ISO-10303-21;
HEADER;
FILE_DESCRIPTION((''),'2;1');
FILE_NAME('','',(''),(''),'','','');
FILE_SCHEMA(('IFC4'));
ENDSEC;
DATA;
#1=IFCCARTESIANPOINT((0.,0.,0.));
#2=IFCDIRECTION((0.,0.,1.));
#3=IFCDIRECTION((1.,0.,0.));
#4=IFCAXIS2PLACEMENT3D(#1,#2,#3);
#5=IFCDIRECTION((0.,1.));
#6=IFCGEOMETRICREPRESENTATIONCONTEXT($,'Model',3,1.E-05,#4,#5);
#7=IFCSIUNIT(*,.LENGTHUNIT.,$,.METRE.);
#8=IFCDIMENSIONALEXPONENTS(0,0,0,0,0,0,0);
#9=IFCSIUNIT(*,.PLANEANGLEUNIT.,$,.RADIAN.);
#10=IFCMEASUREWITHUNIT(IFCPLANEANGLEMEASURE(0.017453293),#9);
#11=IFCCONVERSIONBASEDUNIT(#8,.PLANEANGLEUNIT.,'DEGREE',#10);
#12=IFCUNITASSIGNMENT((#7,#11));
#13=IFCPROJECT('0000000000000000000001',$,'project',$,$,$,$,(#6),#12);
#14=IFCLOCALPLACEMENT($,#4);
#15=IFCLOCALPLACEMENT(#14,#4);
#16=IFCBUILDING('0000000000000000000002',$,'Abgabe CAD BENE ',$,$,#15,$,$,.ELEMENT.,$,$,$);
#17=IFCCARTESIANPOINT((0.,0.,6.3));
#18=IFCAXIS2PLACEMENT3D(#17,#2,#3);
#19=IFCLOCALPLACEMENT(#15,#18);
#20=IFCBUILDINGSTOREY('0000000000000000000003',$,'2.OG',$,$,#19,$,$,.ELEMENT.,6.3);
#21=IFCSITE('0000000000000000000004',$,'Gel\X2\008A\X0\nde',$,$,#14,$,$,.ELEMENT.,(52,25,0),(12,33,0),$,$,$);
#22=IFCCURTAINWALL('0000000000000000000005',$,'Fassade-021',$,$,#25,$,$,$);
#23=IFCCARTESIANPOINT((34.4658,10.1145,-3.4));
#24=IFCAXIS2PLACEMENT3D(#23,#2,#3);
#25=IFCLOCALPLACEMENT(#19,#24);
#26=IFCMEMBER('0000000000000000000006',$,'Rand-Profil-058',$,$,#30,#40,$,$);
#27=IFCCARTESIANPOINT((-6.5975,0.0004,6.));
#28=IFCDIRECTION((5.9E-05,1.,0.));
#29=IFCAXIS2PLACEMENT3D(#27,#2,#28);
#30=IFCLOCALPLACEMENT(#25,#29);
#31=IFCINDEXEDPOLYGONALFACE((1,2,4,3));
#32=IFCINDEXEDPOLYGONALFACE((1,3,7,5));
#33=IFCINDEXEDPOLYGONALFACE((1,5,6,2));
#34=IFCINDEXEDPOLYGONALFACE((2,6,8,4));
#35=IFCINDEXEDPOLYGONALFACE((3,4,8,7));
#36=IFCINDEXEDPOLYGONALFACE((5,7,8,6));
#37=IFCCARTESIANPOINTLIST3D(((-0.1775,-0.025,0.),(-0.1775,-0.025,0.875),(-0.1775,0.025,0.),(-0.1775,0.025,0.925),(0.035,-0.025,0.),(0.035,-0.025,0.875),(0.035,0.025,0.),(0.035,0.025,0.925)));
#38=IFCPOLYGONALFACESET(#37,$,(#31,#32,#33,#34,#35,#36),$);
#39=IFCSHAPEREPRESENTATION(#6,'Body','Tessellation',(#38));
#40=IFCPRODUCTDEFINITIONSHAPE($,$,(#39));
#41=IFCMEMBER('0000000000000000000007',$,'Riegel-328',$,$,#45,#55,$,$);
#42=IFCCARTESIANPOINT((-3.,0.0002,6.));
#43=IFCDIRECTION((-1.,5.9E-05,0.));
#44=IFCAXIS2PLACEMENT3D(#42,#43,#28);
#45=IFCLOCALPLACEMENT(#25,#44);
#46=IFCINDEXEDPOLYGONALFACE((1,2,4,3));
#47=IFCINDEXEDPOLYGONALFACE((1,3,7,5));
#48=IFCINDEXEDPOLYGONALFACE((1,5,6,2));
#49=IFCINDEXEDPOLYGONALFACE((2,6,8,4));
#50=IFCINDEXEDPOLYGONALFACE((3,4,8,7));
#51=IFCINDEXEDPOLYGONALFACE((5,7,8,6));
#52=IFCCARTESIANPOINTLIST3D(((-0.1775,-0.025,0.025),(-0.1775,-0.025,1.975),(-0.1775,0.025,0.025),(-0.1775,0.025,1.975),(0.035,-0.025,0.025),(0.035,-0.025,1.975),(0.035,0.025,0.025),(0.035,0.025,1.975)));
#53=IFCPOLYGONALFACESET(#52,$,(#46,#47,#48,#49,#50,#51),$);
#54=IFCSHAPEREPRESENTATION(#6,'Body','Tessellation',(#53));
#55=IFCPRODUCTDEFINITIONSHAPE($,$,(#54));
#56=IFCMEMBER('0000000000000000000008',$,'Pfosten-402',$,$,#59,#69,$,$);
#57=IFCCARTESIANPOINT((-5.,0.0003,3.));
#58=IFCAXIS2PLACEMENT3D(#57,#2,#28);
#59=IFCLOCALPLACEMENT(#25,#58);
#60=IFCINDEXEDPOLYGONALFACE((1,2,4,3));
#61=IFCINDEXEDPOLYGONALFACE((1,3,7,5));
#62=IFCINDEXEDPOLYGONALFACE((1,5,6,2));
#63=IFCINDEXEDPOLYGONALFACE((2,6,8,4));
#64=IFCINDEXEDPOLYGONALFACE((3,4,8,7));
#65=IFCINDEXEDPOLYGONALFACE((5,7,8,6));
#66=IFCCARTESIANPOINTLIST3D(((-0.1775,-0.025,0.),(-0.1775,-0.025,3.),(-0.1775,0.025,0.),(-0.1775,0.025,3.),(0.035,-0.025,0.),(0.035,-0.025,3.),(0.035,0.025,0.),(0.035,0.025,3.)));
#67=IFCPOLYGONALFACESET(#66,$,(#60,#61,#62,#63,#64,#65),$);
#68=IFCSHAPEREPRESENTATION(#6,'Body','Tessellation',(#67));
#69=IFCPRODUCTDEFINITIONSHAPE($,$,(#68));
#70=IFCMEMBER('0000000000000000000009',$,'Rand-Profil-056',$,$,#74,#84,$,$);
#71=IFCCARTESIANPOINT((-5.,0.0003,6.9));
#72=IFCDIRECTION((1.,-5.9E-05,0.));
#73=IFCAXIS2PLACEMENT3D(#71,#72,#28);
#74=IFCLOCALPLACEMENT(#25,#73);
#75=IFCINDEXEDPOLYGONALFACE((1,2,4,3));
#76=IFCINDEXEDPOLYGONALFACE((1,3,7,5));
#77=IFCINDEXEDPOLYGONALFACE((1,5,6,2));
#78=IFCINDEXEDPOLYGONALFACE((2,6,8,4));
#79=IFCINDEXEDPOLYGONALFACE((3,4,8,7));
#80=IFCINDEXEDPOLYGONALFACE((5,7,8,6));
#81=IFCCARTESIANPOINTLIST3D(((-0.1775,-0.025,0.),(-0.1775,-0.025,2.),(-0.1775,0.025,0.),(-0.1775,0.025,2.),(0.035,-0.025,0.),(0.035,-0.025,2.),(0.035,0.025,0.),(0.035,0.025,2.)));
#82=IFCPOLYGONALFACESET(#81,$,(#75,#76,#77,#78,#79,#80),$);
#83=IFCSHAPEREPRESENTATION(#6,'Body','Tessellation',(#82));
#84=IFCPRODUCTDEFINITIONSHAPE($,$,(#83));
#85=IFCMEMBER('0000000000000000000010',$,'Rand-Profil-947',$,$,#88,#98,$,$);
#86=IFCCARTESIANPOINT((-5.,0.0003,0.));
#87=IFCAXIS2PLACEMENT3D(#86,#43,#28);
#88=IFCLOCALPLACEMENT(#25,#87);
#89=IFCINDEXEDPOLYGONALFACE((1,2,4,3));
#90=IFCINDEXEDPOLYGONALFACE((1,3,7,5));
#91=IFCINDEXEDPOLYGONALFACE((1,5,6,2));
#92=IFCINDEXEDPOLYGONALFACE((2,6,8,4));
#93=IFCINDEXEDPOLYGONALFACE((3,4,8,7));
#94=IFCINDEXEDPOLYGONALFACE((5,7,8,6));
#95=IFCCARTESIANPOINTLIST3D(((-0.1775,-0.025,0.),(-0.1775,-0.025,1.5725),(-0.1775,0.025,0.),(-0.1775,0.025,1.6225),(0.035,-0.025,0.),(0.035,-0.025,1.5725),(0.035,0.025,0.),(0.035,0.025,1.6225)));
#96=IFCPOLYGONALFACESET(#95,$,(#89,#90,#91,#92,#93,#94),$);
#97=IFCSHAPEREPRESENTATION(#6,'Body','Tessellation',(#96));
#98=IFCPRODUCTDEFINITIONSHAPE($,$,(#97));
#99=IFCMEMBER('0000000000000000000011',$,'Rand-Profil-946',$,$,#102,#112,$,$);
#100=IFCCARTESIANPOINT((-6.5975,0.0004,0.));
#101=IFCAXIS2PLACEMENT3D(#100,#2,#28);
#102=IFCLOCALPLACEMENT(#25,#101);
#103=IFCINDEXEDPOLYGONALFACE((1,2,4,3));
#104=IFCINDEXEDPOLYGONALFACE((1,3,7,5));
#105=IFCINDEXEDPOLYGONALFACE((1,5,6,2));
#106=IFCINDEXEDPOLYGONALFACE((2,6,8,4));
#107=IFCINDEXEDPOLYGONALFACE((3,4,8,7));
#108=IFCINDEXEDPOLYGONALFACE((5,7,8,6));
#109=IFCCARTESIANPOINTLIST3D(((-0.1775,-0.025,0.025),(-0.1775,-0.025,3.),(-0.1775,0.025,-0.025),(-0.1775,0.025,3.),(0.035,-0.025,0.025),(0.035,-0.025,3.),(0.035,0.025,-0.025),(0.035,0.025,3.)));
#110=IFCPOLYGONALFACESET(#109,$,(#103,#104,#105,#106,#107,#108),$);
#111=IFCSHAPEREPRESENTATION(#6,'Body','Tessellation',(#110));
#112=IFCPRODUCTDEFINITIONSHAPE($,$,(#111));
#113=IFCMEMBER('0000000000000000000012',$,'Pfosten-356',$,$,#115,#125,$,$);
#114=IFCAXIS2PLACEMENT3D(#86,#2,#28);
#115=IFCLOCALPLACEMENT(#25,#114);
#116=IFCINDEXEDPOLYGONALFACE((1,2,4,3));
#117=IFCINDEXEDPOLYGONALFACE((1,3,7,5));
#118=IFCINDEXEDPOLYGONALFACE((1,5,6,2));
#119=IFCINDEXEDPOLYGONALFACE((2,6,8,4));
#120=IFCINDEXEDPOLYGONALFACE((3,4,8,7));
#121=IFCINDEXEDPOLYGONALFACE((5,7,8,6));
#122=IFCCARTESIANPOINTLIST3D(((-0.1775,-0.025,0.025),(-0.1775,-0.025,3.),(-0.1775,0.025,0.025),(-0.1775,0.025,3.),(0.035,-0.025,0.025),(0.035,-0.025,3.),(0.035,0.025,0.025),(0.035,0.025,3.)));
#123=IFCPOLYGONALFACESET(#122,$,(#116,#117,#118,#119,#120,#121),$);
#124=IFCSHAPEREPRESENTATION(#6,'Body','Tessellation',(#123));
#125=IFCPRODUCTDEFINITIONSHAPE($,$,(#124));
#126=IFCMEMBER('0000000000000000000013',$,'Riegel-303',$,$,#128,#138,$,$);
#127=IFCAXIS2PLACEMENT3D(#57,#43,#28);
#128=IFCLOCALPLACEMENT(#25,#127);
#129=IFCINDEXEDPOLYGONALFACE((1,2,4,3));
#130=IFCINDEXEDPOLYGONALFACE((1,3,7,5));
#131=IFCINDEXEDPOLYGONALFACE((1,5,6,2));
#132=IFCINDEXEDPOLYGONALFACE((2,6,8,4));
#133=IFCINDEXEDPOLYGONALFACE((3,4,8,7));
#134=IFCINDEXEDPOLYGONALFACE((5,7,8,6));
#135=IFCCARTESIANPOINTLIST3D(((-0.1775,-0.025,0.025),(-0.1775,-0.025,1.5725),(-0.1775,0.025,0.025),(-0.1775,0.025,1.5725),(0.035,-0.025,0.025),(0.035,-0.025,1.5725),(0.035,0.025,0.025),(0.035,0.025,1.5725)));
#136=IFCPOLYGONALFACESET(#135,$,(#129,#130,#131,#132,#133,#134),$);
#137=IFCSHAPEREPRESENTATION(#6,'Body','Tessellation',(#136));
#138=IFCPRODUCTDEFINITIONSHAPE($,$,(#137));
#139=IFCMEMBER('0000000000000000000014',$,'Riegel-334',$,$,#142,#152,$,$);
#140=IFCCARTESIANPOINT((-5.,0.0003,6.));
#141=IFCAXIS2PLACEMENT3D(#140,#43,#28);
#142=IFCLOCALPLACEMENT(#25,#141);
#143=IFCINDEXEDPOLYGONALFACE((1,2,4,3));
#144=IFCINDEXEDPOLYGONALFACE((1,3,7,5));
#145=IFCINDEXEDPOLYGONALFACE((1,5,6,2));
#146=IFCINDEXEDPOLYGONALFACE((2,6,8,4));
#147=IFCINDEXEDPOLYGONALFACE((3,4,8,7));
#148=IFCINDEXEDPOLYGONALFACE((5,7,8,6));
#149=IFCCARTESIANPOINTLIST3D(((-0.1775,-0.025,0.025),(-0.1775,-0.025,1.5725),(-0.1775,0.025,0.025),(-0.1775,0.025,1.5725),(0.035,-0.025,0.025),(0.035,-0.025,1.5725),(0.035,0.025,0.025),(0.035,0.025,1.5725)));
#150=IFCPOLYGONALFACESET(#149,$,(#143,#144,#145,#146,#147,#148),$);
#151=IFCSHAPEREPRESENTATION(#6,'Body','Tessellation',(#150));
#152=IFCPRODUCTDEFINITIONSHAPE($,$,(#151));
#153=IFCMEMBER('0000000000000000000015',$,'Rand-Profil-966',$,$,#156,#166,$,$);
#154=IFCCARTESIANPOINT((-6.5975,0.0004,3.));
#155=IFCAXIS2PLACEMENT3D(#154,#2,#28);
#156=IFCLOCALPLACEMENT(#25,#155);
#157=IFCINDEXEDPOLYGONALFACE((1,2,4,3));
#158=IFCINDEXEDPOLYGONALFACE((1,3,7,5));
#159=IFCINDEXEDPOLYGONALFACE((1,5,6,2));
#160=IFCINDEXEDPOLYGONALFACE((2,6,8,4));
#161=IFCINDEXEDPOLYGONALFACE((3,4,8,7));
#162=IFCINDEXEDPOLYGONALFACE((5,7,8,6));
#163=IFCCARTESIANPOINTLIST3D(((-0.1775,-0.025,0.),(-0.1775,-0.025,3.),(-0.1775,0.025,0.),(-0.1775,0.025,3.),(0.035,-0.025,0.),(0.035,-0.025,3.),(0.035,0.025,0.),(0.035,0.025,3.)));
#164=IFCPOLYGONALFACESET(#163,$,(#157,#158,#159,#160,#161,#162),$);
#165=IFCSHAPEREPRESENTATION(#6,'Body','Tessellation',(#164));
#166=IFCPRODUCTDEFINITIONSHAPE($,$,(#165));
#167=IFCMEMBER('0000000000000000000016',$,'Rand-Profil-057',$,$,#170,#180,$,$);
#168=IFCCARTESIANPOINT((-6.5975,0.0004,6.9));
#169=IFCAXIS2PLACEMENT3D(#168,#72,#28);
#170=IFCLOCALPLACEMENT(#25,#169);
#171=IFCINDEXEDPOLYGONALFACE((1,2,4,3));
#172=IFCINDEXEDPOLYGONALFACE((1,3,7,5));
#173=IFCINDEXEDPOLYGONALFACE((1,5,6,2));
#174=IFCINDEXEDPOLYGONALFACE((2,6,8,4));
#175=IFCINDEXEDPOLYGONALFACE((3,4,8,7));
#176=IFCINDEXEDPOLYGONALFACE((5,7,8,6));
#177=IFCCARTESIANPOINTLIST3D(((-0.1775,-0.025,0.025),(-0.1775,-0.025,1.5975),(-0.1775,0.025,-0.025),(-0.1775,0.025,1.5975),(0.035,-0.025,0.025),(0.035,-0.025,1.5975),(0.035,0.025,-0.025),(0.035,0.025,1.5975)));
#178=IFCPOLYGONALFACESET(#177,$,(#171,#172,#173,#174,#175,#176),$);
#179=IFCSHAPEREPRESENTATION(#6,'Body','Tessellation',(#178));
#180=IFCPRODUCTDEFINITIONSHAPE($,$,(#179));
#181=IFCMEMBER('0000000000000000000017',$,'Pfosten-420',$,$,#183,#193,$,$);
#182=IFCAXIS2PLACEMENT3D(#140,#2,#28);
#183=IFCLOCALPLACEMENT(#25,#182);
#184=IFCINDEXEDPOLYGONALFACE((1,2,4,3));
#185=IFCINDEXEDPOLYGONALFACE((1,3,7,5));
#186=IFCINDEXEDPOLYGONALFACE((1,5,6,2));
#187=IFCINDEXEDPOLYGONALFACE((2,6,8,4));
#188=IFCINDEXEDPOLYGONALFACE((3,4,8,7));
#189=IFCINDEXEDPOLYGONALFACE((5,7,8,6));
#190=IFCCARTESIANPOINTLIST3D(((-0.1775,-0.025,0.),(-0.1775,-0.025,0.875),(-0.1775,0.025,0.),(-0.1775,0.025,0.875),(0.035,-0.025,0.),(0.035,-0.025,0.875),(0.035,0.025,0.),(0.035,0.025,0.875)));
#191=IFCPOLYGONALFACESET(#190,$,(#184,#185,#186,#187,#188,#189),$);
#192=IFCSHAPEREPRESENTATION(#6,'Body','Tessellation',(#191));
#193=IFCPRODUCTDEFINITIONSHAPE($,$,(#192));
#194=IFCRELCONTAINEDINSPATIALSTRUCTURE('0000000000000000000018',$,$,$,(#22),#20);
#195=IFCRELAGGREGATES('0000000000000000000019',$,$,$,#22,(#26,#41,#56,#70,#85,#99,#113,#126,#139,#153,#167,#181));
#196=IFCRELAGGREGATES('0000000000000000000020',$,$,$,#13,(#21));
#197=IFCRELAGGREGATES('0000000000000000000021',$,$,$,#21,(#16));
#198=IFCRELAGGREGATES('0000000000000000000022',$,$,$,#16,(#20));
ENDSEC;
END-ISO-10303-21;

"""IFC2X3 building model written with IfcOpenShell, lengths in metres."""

from ifc_helpers import new_model, entity, si_unit, converted_unit, direction, frame, origin_with_axes, place, context, project, spatial, polyline, outline, extrude, clip, halfspace, element, aggregate, save


model = new_model("IFC2X3")

# Units and contexts
model_context = context("Model", 3, precision=1e-05, world=origin_with_axes(), true_north=direction((0.0, 1.0)))
ifc_project = project(units=[si_unit("LENGTHUNIT", "METRE"), converted_unit("PLANEANGLEUNIT", "DEGREE", entity("IfcPlaneAngleMeasure", 0.017453293), si_unit("PLANEANGLEUNIT", "RADIAN"), dimensions=[0, 0, 0, 0, 0, 0, 0])], contexts=[model_context])

# Site, building, storey
site_placement = place(None, origin_with_axes())
site = spatial("IfcSite", under=ifc_project, at=site_placement, Name="Gel\u008ande", CompositionType="ELEMENT", RefLatitude=(52, 25, 0), RefLongitude=(12, 33, 0))
building_placement = place(site_placement, origin_with_axes())
building = spatial("IfcBuilding", under=site, at=building_placement, Name="Abgabe CAD BENE ", CompositionType="ELEMENT")
storey_placement = place(building_placement, frame((0.0, 0.0, 6.3), z_axis=(0.0, 0.0, 1.0), x_axis=(1.0, 0.0, 0.0)))
storey = spatial("IfcBuildingStorey", under=building, at=storey_placement, Name="2.OG", CompositionType="ELEMENT", Elevation=6.3)

# Curtain wall, members
curtain_wall_placement = place(storey_placement, frame((34.4658, 10.1145, -3.4), z_axis=(0.0, 0.0, 1.0), x_axis=(1.0, 0.0, 0.0)))
curtain_wall = element("IfcCurtainWall", 1, at=curtain_wall_placement, inside=storey, Name="Fassade-021")
member_1_placement = place(curtain_wall_placement, frame((-6.5975, 0.0004, 6.0), z_axis=(0.0, 0.0, 1.0), x_axis=(0.000059, 1.0, 0.0)))
member_1 = element("IfcMember", 2, at=member_1_placement, Name="Rand-Profil-058", context=model_context, shape_type="Clipping", body=[
    clip(extrude(outline(polyline([(0.025, -0.1775), (0.025, 0.035), (-0.025, 0.035), (-0.025, -0.1775), (0.025, -0.1775)])), frame((0.0, 0.0, 0.0), z_axis=(0.0, 0.0, 1.0), x_axis=(0.000059, -1.0, 0.0)), (0.0, 0.0, 1.0), 0.925), halfspace(frame((0.0, -0.45, 0.45), z_axis=(0.0, 0.707107, -0.707107), x_axis=(0.0, -0.707107, -0.707107)), True)),
])
member_2_placement = place(curtain_wall_placement, frame((-3.0, 0.0002, 6.0), z_axis=(-1.0, 0.000059, 0.0), x_axis=(0.000059, 1.0, 0.0)))
member_2 = element("IfcMember", 3, at=member_2_placement, Name="Riegel-328", context=model_context, shape_type="SweptSolid", body=[
    extrude(outline(polyline([(-0.1775, -0.025), (0.035, -0.025), (0.035, 0.025), (-0.1775, 0.025), (-0.1775, -0.025)])), frame((0.0, 0.0, 0.025), z_axis=(0.0, 0.0, 1.0), x_axis=(1.0, 0.0, 0.0)), (0.0, 0.0, 1.0), 1.95),
])
member_3_placement = place(curtain_wall_placement, frame((-5.0, 0.0003, 3.0), z_axis=(0.0, 0.0, 1.0), x_axis=(0.000059, 1.0, 0.0)))
member_3 = element("IfcMember", 4, at=member_3_placement, Name="Pfosten-402", context=model_context, shape_type="SweptSolid", body=[
    extrude(outline(polyline([(0.025, -0.1775), (0.025, 0.035), (-0.025, 0.035), (-0.025, -0.1775), (0.025, -0.1775)])), frame((0.0, 0.0, 0.0), z_axis=(0.0, 0.0, 1.0), x_axis=(0.000059, -1.0, 0.0)), (0.0, 0.0, 1.0), 3.0),
])
member_4_placement = place(curtain_wall_placement, frame((-5.0, 0.0003, 6.9), z_axis=(1.0, -0.000059, 0.0), x_axis=(0.000059, 1.0, 0.0)))
member_4 = element("IfcMember", 5, at=member_4_placement, Name="Rand-Profil-056", context=model_context, shape_type="SweptSolid", body=[
    extrude(outline(polyline([(0.1775, 0.025), (-0.035, 0.025), (-0.035, -0.025), (0.1775, -0.025), (0.1775, 0.025)])), frame((0.0, 0.0, 0.0), z_axis=(0.0, 0.0, 1.0), x_axis=(-1.0, 0.0, 0.0)), (0.0, 0.0, 1.0), 2.0),
])
member_5_placement = place(curtain_wall_placement, frame((-5.0, 0.0003, 0.0), z_axis=(-1.0, 0.000059, 0.0), x_axis=(0.000059, 1.0, 0.0)))
member_5 = element("IfcMember", 6, at=member_5_placement, Name="Rand-Profil-947", context=model_context, shape_type="Clipping", body=[
    clip(extrude(outline(polyline([(-0.1775, -0.025), (0.035, -0.025), (0.035, 0.025), (-0.1775, 0.025), (-0.1775, -0.025)])), origin_with_axes(), (0.0, 0.0, 1.0), 1.6225), halfspace(frame((0.0, -0.7988, 0.7988), z_axis=(0.0, 0.707107, -0.707107), x_axis=(0.0, -0.707107, -0.707107)), True)),
])
member_6_placement = place(curtain_wall_placement, frame((-6.5975, 0.0004, 0.0), z_axis=(0.0, 0.0, 1.0), x_axis=(0.000059, 1.0, 0.0)))
member_6 = element("IfcMember", 7, at=member_6_placement, Name="Rand-Profil-946", context=model_context, shape_type="Clipping", body=[
    clip(extrude(outline(polyline([(0.025, -0.1775), (0.025, 0.035), (-0.025, 0.035), (-0.025, -0.1775), (0.025, -0.1775)])), frame((0.0, 0.0, -0.025), z_axis=(0.0, 0.0, 1.0), x_axis=(0.000059, -1.0, 0.0)), (0.0, 0.0, 1.0), 3.025), halfspace(frame((0.0, 0.0, 0.0), z_axis=(0.0, 0.707107, 0.707107), x_axis=(0.0, 0.707107, -0.707107)), True)),
])
member_7_placement = place(curtain_wall_placement, frame((-5.0, 0.0003, 0.0), z_axis=(0.0, 0.0, 1.0), x_axis=(0.000059, 1.0, 0.0)))
member_7 = element("IfcMember", 8, at=member_7_placement, Name="Pfosten-356", context=model_context, shape_type="SweptSolid", body=[
    extrude(outline(polyline([(0.025, -0.1775), (0.025, 0.035), (-0.025, 0.035), (-0.025, -0.1775), (0.025, -0.1775)])), frame((0.0, 0.0, 0.025), z_axis=(0.0, 0.0, 1.0), x_axis=(0.000059, -1.0, 0.0)), (0.0, 0.0, 1.0), 2.975),
])
member_8_placement = place(curtain_wall_placement, frame((-5.0, 0.0003, 3.0), z_axis=(-1.0, 0.000059, 0.0), x_axis=(0.000059, 1.0, 0.0)))
member_8 = element("IfcMember", 9, at=member_8_placement, Name="Riegel-303", context=model_context, shape_type="SweptSolid", body=[
    extrude(outline(polyline([(-0.1775, -0.025), (0.035, -0.025), (0.035, 0.025), (-0.1775, 0.025), (-0.1775, -0.025)])), frame((0.0, 0.0, 0.025), z_axis=(0.0, 0.0, 1.0), x_axis=(1.0, 0.0, 0.0)), (0.0, 0.0, 1.0), 1.5475),
])
member_9_placement = place(curtain_wall_placement, frame((-5.0, 0.0003, 6.0), z_axis=(-1.0, 0.000059, 0.0), x_axis=(0.000059, 1.0, 0.0)))
member_9 = element("IfcMember", 10, at=member_9_placement, Name="Riegel-334", context=model_context, shape_type="SweptSolid", body=[
    extrude(outline(polyline([(-0.1775, -0.025), (0.035, -0.025), (0.035, 0.025), (-0.1775, 0.025), (-0.1775, -0.025)])), frame((0.0, 0.0, 0.025), z_axis=(0.0, 0.0, 1.0), x_axis=(1.0, 0.0, 0.0)), (0.0, 0.0, 1.0), 1.5475),
])
member_10_placement = place(curtain_wall_placement, frame((-6.5975, 0.0004, 3.0), z_axis=(0.0, 0.0, 1.0), x_axis=(0.000059, 1.0, 0.0)))
member_10 = element("IfcMember", 11, at=member_10_placement, Name="Rand-Profil-966", context=model_context, shape_type="SweptSolid", body=[
    extrude(outline(polyline([(0.025, -0.1775), (0.025, 0.035), (-0.025, 0.035), (-0.025, -0.1775), (0.025, -0.1775)])), frame((0.0, 0.0, 0.0), z_axis=(0.0, 0.0, 1.0), x_axis=(0.000059, -1.0, 0.0)), (0.0, 0.0, 1.0), 3.0),
])
member_11_placement = place(curtain_wall_placement, frame((-6.5975, 0.0004, 6.9), z_axis=(1.0, -0.000059, 0.0), x_axis=(0.000059, 1.0, 0.0)))
member_11 = element("IfcMember", 12, at=member_11_placement, Name="Rand-Profil-057", context=model_context, shape_type="Clipping", body=[
    clip(extrude(outline(polyline([(0.1775, 0.025), (-0.035, 0.025), (-0.035, -0.025), (0.1775, -0.025), (0.1775, 0.025)])), frame((0.0, 0.0, -0.025), z_axis=(0.0, 0.0, 1.0), x_axis=(-1.0, 0.0, 0.0)), (0.0, 0.0, 1.0), 1.6225), halfspace(frame((0.0, 0.0, 0.0), z_axis=(0.0, 0.707107, 0.707107), x_axis=(0.0, 0.707107, -0.707107)), True)),
])
member_12_placement = place(curtain_wall_placement, frame((-5.0, 0.0003, 6.0), z_axis=(0.0, 0.0, 1.0), x_axis=(0.000059, 1.0, 0.0)))
member_12 = element("IfcMember", 13, at=member_12_placement, Name="Pfosten-420", context=model_context, shape_type="SweptSolid", body=[
    extrude(outline(polyline([(0.025, -0.1775), (0.025, 0.035), (-0.025, 0.035), (-0.025, -0.1775), (0.025, -0.1775)])), frame((0.0, 0.0, 0.0), z_axis=(0.0, 0.0, 1.0), x_axis=(0.000059, -1.0, 0.0)), (0.0, 0.0, 1.0), 0.875),
])
aggregate(curtain_wall, [member_1, member_2, member_3, member_4, member_5, member_6, member_7, member_8, member_9, member_10, member_11, member_12])

save(model, "model.ifc")
